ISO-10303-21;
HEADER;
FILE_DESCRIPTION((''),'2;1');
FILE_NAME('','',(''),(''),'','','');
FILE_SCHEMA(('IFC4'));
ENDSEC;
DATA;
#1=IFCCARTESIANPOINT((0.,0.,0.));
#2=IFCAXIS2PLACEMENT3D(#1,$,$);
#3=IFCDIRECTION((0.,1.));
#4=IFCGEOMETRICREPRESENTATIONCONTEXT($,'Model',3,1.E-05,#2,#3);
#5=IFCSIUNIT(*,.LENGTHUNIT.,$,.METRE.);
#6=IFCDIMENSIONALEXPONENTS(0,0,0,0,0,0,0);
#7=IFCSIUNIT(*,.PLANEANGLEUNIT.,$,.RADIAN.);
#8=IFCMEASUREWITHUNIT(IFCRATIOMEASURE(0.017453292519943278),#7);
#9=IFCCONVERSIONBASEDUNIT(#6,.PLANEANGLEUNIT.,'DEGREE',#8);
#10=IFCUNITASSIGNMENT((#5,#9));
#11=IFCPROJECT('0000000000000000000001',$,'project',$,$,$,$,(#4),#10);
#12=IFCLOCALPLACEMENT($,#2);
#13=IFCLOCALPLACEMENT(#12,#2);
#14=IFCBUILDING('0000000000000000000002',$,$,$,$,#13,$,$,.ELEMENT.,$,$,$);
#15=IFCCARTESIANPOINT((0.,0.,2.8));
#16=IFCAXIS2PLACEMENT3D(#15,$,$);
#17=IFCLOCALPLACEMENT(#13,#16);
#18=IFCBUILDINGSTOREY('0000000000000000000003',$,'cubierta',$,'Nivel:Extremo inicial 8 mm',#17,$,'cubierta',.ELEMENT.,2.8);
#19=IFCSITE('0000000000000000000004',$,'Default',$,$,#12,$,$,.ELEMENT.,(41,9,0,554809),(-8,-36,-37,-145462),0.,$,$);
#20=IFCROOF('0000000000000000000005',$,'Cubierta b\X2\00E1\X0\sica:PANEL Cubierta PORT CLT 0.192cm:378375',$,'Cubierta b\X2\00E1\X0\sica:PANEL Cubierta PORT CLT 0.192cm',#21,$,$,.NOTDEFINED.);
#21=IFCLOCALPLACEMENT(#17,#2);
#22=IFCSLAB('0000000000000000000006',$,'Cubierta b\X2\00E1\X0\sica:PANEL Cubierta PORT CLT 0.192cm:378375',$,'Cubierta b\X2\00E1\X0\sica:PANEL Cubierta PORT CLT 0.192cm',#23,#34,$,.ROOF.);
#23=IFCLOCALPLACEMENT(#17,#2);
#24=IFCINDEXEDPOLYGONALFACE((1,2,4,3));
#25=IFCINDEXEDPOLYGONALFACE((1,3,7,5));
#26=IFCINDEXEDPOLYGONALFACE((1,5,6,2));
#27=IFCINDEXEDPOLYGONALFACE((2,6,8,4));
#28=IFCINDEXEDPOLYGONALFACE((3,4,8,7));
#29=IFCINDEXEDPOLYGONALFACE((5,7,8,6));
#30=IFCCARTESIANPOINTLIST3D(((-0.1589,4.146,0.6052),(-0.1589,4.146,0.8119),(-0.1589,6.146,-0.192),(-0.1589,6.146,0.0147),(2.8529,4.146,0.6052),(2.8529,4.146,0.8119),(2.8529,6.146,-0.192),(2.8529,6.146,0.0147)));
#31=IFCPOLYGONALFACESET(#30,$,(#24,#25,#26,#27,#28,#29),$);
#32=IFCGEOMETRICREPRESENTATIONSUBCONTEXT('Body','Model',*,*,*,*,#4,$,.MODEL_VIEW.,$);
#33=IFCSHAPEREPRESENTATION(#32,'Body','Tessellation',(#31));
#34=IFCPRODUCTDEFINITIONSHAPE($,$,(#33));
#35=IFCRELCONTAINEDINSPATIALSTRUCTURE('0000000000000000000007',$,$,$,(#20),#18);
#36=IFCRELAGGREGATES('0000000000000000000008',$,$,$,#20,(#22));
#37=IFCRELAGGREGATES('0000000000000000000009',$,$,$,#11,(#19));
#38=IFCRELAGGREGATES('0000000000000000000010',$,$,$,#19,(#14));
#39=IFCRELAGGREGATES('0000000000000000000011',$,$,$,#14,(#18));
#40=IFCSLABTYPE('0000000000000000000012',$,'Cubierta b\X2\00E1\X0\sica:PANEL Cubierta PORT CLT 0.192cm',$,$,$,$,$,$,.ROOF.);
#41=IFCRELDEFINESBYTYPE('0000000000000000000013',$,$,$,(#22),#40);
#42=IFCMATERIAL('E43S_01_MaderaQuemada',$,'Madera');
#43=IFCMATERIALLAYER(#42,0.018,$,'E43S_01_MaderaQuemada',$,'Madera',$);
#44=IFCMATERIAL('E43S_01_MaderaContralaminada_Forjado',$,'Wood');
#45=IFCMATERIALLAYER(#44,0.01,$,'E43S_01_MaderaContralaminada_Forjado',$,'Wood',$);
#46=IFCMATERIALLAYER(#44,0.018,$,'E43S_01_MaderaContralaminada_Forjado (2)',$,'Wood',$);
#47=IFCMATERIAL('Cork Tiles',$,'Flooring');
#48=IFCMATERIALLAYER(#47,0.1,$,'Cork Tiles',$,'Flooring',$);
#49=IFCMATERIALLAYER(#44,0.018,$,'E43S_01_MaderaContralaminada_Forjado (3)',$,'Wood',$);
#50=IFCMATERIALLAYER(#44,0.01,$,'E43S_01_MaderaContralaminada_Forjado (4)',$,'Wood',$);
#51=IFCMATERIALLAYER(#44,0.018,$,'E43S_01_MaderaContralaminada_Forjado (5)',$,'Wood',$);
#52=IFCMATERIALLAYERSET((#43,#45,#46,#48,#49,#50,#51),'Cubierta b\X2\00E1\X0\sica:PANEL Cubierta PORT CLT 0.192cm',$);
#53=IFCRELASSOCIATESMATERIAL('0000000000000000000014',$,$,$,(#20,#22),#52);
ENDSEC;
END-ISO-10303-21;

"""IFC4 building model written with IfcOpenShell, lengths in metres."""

from ifc_helpers import new_model, entity, si_unit, converted_unit, direction, frame, frame_2d, origin, place, context, subcontext, project, spatial, rectangle, extrude, material, layer, layer_set, type_object, element, aggregate, save


model = new_model("IFC4")

# Units and contexts
model_context = context("Model", 3, precision=1e-05, world=origin(), true_north=direction((0.0, 1.0)))
body_context = subcontext(model_context, "Body", "Model", "MODEL_VIEW")
ifc_project = project(units=[si_unit("LENGTHUNIT", "METRE"), converted_unit("PLANEANGLEUNIT", "DEGREE", entity("IfcRatioMeasure", 0.017453292519943278), si_unit("PLANEANGLEUNIT", "RADIAN"), dimensions=[0, 0, 0, 0, 0, 0, 0])], contexts=[model_context])

# Site, building, storey
site_placement = place(None, origin())
site = spatial("IfcSite", under=ifc_project, at=site_placement, Name="Default", CompositionType="ELEMENT", RefLatitude=(41, 9, 0, 554809), RefLongitude=(-8, -36, -37, -145462), RefElevation=0.0)
building_placement = place(site_placement, origin())
building = spatial("IfcBuilding", under=site, at=building_placement, CompositionType="ELEMENT")
storey_placement = place(building_placement, frame((0.0, 0.0, 2.8)))
storey = spatial("IfcBuildingStorey", under=building, at=storey_placement, Name="cubierta", ObjectType="Nivel:Extremo inicial 8 mm", LongName="cubierta", CompositionType="ELEMENT", Elevation=2.8)

# Roof, slab
ifc_material_1 = material(Name="E43S_01_MaderaQuemada", Category="Madera")
ifc_layer_1 = layer(ifc_material_1, 0.018, Name="E43S_01_MaderaQuemada", Category="Madera")
ifc_material_2 = material(Name="E43S_01_MaderaContralaminada_Forjado", Category="Wood")
ifc_layer_2 = layer(ifc_material_2, 0.01, Name="E43S_01_MaderaContralaminada_Forjado", Category="Wood")
ifc_layer_3 = layer(ifc_material_2, 0.018, Name="E43S_01_MaderaContralaminada_Forjado (2)", Category="Wood")
ifc_material_3 = material(Name="Cork Tiles", Category="Flooring")
ifc_layer_4 = layer(ifc_material_3, 0.1, Name="Cork Tiles", Category="Flooring")
ifc_layer_5 = layer(ifc_material_2, 0.018, Name="E43S_01_MaderaContralaminada_Forjado (3)", Category="Wood")
ifc_layer_6 = layer(ifc_material_2, 0.01, Name="E43S_01_MaderaContralaminada_Forjado (4)", Category="Wood")
ifc_layer_7 = layer(ifc_material_2, 0.018, Name="E43S_01_MaderaContralaminada_Forjado (5)", Category="Wood")
ifc_layer_set = layer_set([ifc_layer_1, ifc_layer_2, ifc_layer_3, ifc_layer_4, ifc_layer_5, ifc_layer_6, ifc_layer_7], Name="Cubierta básica:PANEL Cubierta PORT CLT 0.192cm")
roof_placement = place(storey_placement, frame((-0.1589, 4.146, -0.192)))
roof = element("IfcRoof", 1, at=roof_placement, inside=storey, material=ifc_layer_set, Name="Cubierta básica:PANEL Cubierta PORT CLT 0.192cm:378375", ObjectType="Cubierta básica:PANEL Cubierta PORT CLT 0.192cm", PredefinedType="NOTDEFINED")
slab_type = type_object("IfcSlabType", Name="Cubierta básica:PANEL Cubierta PORT CLT 0.192cm", PredefinedType="ROOF")
slab_placement = place(roof_placement, origin())
slab = element("IfcSlab", 2, at=slab_placement, type_object=slab_type, material=ifc_layer_set, Name="Cubierta básica:PANEL Cubierta PORT CLT 0.192cm:378375", ObjectType="Cubierta básica:PANEL Cubierta PORT CLT 0.192cm", PredefinedType="ROOF", context=body_context, shape_type="SweptSolid", body=[
    extrude(rectangle(XDim=2.153, YDim=3.0118, at=frame_2d((0.0, 0.0), x_axis=(0.0, 1.0))), frame((1.5059, 1.0, 0.3986), z_axis=(0.0, 0.370288, 0.928917), x_axis=(1.0, 0.0, 0.0)), (0.0, -0.370288, 0.928917), 0.2067),
])
aggregate(roof, [slab])

save(model, "model.ifc")
